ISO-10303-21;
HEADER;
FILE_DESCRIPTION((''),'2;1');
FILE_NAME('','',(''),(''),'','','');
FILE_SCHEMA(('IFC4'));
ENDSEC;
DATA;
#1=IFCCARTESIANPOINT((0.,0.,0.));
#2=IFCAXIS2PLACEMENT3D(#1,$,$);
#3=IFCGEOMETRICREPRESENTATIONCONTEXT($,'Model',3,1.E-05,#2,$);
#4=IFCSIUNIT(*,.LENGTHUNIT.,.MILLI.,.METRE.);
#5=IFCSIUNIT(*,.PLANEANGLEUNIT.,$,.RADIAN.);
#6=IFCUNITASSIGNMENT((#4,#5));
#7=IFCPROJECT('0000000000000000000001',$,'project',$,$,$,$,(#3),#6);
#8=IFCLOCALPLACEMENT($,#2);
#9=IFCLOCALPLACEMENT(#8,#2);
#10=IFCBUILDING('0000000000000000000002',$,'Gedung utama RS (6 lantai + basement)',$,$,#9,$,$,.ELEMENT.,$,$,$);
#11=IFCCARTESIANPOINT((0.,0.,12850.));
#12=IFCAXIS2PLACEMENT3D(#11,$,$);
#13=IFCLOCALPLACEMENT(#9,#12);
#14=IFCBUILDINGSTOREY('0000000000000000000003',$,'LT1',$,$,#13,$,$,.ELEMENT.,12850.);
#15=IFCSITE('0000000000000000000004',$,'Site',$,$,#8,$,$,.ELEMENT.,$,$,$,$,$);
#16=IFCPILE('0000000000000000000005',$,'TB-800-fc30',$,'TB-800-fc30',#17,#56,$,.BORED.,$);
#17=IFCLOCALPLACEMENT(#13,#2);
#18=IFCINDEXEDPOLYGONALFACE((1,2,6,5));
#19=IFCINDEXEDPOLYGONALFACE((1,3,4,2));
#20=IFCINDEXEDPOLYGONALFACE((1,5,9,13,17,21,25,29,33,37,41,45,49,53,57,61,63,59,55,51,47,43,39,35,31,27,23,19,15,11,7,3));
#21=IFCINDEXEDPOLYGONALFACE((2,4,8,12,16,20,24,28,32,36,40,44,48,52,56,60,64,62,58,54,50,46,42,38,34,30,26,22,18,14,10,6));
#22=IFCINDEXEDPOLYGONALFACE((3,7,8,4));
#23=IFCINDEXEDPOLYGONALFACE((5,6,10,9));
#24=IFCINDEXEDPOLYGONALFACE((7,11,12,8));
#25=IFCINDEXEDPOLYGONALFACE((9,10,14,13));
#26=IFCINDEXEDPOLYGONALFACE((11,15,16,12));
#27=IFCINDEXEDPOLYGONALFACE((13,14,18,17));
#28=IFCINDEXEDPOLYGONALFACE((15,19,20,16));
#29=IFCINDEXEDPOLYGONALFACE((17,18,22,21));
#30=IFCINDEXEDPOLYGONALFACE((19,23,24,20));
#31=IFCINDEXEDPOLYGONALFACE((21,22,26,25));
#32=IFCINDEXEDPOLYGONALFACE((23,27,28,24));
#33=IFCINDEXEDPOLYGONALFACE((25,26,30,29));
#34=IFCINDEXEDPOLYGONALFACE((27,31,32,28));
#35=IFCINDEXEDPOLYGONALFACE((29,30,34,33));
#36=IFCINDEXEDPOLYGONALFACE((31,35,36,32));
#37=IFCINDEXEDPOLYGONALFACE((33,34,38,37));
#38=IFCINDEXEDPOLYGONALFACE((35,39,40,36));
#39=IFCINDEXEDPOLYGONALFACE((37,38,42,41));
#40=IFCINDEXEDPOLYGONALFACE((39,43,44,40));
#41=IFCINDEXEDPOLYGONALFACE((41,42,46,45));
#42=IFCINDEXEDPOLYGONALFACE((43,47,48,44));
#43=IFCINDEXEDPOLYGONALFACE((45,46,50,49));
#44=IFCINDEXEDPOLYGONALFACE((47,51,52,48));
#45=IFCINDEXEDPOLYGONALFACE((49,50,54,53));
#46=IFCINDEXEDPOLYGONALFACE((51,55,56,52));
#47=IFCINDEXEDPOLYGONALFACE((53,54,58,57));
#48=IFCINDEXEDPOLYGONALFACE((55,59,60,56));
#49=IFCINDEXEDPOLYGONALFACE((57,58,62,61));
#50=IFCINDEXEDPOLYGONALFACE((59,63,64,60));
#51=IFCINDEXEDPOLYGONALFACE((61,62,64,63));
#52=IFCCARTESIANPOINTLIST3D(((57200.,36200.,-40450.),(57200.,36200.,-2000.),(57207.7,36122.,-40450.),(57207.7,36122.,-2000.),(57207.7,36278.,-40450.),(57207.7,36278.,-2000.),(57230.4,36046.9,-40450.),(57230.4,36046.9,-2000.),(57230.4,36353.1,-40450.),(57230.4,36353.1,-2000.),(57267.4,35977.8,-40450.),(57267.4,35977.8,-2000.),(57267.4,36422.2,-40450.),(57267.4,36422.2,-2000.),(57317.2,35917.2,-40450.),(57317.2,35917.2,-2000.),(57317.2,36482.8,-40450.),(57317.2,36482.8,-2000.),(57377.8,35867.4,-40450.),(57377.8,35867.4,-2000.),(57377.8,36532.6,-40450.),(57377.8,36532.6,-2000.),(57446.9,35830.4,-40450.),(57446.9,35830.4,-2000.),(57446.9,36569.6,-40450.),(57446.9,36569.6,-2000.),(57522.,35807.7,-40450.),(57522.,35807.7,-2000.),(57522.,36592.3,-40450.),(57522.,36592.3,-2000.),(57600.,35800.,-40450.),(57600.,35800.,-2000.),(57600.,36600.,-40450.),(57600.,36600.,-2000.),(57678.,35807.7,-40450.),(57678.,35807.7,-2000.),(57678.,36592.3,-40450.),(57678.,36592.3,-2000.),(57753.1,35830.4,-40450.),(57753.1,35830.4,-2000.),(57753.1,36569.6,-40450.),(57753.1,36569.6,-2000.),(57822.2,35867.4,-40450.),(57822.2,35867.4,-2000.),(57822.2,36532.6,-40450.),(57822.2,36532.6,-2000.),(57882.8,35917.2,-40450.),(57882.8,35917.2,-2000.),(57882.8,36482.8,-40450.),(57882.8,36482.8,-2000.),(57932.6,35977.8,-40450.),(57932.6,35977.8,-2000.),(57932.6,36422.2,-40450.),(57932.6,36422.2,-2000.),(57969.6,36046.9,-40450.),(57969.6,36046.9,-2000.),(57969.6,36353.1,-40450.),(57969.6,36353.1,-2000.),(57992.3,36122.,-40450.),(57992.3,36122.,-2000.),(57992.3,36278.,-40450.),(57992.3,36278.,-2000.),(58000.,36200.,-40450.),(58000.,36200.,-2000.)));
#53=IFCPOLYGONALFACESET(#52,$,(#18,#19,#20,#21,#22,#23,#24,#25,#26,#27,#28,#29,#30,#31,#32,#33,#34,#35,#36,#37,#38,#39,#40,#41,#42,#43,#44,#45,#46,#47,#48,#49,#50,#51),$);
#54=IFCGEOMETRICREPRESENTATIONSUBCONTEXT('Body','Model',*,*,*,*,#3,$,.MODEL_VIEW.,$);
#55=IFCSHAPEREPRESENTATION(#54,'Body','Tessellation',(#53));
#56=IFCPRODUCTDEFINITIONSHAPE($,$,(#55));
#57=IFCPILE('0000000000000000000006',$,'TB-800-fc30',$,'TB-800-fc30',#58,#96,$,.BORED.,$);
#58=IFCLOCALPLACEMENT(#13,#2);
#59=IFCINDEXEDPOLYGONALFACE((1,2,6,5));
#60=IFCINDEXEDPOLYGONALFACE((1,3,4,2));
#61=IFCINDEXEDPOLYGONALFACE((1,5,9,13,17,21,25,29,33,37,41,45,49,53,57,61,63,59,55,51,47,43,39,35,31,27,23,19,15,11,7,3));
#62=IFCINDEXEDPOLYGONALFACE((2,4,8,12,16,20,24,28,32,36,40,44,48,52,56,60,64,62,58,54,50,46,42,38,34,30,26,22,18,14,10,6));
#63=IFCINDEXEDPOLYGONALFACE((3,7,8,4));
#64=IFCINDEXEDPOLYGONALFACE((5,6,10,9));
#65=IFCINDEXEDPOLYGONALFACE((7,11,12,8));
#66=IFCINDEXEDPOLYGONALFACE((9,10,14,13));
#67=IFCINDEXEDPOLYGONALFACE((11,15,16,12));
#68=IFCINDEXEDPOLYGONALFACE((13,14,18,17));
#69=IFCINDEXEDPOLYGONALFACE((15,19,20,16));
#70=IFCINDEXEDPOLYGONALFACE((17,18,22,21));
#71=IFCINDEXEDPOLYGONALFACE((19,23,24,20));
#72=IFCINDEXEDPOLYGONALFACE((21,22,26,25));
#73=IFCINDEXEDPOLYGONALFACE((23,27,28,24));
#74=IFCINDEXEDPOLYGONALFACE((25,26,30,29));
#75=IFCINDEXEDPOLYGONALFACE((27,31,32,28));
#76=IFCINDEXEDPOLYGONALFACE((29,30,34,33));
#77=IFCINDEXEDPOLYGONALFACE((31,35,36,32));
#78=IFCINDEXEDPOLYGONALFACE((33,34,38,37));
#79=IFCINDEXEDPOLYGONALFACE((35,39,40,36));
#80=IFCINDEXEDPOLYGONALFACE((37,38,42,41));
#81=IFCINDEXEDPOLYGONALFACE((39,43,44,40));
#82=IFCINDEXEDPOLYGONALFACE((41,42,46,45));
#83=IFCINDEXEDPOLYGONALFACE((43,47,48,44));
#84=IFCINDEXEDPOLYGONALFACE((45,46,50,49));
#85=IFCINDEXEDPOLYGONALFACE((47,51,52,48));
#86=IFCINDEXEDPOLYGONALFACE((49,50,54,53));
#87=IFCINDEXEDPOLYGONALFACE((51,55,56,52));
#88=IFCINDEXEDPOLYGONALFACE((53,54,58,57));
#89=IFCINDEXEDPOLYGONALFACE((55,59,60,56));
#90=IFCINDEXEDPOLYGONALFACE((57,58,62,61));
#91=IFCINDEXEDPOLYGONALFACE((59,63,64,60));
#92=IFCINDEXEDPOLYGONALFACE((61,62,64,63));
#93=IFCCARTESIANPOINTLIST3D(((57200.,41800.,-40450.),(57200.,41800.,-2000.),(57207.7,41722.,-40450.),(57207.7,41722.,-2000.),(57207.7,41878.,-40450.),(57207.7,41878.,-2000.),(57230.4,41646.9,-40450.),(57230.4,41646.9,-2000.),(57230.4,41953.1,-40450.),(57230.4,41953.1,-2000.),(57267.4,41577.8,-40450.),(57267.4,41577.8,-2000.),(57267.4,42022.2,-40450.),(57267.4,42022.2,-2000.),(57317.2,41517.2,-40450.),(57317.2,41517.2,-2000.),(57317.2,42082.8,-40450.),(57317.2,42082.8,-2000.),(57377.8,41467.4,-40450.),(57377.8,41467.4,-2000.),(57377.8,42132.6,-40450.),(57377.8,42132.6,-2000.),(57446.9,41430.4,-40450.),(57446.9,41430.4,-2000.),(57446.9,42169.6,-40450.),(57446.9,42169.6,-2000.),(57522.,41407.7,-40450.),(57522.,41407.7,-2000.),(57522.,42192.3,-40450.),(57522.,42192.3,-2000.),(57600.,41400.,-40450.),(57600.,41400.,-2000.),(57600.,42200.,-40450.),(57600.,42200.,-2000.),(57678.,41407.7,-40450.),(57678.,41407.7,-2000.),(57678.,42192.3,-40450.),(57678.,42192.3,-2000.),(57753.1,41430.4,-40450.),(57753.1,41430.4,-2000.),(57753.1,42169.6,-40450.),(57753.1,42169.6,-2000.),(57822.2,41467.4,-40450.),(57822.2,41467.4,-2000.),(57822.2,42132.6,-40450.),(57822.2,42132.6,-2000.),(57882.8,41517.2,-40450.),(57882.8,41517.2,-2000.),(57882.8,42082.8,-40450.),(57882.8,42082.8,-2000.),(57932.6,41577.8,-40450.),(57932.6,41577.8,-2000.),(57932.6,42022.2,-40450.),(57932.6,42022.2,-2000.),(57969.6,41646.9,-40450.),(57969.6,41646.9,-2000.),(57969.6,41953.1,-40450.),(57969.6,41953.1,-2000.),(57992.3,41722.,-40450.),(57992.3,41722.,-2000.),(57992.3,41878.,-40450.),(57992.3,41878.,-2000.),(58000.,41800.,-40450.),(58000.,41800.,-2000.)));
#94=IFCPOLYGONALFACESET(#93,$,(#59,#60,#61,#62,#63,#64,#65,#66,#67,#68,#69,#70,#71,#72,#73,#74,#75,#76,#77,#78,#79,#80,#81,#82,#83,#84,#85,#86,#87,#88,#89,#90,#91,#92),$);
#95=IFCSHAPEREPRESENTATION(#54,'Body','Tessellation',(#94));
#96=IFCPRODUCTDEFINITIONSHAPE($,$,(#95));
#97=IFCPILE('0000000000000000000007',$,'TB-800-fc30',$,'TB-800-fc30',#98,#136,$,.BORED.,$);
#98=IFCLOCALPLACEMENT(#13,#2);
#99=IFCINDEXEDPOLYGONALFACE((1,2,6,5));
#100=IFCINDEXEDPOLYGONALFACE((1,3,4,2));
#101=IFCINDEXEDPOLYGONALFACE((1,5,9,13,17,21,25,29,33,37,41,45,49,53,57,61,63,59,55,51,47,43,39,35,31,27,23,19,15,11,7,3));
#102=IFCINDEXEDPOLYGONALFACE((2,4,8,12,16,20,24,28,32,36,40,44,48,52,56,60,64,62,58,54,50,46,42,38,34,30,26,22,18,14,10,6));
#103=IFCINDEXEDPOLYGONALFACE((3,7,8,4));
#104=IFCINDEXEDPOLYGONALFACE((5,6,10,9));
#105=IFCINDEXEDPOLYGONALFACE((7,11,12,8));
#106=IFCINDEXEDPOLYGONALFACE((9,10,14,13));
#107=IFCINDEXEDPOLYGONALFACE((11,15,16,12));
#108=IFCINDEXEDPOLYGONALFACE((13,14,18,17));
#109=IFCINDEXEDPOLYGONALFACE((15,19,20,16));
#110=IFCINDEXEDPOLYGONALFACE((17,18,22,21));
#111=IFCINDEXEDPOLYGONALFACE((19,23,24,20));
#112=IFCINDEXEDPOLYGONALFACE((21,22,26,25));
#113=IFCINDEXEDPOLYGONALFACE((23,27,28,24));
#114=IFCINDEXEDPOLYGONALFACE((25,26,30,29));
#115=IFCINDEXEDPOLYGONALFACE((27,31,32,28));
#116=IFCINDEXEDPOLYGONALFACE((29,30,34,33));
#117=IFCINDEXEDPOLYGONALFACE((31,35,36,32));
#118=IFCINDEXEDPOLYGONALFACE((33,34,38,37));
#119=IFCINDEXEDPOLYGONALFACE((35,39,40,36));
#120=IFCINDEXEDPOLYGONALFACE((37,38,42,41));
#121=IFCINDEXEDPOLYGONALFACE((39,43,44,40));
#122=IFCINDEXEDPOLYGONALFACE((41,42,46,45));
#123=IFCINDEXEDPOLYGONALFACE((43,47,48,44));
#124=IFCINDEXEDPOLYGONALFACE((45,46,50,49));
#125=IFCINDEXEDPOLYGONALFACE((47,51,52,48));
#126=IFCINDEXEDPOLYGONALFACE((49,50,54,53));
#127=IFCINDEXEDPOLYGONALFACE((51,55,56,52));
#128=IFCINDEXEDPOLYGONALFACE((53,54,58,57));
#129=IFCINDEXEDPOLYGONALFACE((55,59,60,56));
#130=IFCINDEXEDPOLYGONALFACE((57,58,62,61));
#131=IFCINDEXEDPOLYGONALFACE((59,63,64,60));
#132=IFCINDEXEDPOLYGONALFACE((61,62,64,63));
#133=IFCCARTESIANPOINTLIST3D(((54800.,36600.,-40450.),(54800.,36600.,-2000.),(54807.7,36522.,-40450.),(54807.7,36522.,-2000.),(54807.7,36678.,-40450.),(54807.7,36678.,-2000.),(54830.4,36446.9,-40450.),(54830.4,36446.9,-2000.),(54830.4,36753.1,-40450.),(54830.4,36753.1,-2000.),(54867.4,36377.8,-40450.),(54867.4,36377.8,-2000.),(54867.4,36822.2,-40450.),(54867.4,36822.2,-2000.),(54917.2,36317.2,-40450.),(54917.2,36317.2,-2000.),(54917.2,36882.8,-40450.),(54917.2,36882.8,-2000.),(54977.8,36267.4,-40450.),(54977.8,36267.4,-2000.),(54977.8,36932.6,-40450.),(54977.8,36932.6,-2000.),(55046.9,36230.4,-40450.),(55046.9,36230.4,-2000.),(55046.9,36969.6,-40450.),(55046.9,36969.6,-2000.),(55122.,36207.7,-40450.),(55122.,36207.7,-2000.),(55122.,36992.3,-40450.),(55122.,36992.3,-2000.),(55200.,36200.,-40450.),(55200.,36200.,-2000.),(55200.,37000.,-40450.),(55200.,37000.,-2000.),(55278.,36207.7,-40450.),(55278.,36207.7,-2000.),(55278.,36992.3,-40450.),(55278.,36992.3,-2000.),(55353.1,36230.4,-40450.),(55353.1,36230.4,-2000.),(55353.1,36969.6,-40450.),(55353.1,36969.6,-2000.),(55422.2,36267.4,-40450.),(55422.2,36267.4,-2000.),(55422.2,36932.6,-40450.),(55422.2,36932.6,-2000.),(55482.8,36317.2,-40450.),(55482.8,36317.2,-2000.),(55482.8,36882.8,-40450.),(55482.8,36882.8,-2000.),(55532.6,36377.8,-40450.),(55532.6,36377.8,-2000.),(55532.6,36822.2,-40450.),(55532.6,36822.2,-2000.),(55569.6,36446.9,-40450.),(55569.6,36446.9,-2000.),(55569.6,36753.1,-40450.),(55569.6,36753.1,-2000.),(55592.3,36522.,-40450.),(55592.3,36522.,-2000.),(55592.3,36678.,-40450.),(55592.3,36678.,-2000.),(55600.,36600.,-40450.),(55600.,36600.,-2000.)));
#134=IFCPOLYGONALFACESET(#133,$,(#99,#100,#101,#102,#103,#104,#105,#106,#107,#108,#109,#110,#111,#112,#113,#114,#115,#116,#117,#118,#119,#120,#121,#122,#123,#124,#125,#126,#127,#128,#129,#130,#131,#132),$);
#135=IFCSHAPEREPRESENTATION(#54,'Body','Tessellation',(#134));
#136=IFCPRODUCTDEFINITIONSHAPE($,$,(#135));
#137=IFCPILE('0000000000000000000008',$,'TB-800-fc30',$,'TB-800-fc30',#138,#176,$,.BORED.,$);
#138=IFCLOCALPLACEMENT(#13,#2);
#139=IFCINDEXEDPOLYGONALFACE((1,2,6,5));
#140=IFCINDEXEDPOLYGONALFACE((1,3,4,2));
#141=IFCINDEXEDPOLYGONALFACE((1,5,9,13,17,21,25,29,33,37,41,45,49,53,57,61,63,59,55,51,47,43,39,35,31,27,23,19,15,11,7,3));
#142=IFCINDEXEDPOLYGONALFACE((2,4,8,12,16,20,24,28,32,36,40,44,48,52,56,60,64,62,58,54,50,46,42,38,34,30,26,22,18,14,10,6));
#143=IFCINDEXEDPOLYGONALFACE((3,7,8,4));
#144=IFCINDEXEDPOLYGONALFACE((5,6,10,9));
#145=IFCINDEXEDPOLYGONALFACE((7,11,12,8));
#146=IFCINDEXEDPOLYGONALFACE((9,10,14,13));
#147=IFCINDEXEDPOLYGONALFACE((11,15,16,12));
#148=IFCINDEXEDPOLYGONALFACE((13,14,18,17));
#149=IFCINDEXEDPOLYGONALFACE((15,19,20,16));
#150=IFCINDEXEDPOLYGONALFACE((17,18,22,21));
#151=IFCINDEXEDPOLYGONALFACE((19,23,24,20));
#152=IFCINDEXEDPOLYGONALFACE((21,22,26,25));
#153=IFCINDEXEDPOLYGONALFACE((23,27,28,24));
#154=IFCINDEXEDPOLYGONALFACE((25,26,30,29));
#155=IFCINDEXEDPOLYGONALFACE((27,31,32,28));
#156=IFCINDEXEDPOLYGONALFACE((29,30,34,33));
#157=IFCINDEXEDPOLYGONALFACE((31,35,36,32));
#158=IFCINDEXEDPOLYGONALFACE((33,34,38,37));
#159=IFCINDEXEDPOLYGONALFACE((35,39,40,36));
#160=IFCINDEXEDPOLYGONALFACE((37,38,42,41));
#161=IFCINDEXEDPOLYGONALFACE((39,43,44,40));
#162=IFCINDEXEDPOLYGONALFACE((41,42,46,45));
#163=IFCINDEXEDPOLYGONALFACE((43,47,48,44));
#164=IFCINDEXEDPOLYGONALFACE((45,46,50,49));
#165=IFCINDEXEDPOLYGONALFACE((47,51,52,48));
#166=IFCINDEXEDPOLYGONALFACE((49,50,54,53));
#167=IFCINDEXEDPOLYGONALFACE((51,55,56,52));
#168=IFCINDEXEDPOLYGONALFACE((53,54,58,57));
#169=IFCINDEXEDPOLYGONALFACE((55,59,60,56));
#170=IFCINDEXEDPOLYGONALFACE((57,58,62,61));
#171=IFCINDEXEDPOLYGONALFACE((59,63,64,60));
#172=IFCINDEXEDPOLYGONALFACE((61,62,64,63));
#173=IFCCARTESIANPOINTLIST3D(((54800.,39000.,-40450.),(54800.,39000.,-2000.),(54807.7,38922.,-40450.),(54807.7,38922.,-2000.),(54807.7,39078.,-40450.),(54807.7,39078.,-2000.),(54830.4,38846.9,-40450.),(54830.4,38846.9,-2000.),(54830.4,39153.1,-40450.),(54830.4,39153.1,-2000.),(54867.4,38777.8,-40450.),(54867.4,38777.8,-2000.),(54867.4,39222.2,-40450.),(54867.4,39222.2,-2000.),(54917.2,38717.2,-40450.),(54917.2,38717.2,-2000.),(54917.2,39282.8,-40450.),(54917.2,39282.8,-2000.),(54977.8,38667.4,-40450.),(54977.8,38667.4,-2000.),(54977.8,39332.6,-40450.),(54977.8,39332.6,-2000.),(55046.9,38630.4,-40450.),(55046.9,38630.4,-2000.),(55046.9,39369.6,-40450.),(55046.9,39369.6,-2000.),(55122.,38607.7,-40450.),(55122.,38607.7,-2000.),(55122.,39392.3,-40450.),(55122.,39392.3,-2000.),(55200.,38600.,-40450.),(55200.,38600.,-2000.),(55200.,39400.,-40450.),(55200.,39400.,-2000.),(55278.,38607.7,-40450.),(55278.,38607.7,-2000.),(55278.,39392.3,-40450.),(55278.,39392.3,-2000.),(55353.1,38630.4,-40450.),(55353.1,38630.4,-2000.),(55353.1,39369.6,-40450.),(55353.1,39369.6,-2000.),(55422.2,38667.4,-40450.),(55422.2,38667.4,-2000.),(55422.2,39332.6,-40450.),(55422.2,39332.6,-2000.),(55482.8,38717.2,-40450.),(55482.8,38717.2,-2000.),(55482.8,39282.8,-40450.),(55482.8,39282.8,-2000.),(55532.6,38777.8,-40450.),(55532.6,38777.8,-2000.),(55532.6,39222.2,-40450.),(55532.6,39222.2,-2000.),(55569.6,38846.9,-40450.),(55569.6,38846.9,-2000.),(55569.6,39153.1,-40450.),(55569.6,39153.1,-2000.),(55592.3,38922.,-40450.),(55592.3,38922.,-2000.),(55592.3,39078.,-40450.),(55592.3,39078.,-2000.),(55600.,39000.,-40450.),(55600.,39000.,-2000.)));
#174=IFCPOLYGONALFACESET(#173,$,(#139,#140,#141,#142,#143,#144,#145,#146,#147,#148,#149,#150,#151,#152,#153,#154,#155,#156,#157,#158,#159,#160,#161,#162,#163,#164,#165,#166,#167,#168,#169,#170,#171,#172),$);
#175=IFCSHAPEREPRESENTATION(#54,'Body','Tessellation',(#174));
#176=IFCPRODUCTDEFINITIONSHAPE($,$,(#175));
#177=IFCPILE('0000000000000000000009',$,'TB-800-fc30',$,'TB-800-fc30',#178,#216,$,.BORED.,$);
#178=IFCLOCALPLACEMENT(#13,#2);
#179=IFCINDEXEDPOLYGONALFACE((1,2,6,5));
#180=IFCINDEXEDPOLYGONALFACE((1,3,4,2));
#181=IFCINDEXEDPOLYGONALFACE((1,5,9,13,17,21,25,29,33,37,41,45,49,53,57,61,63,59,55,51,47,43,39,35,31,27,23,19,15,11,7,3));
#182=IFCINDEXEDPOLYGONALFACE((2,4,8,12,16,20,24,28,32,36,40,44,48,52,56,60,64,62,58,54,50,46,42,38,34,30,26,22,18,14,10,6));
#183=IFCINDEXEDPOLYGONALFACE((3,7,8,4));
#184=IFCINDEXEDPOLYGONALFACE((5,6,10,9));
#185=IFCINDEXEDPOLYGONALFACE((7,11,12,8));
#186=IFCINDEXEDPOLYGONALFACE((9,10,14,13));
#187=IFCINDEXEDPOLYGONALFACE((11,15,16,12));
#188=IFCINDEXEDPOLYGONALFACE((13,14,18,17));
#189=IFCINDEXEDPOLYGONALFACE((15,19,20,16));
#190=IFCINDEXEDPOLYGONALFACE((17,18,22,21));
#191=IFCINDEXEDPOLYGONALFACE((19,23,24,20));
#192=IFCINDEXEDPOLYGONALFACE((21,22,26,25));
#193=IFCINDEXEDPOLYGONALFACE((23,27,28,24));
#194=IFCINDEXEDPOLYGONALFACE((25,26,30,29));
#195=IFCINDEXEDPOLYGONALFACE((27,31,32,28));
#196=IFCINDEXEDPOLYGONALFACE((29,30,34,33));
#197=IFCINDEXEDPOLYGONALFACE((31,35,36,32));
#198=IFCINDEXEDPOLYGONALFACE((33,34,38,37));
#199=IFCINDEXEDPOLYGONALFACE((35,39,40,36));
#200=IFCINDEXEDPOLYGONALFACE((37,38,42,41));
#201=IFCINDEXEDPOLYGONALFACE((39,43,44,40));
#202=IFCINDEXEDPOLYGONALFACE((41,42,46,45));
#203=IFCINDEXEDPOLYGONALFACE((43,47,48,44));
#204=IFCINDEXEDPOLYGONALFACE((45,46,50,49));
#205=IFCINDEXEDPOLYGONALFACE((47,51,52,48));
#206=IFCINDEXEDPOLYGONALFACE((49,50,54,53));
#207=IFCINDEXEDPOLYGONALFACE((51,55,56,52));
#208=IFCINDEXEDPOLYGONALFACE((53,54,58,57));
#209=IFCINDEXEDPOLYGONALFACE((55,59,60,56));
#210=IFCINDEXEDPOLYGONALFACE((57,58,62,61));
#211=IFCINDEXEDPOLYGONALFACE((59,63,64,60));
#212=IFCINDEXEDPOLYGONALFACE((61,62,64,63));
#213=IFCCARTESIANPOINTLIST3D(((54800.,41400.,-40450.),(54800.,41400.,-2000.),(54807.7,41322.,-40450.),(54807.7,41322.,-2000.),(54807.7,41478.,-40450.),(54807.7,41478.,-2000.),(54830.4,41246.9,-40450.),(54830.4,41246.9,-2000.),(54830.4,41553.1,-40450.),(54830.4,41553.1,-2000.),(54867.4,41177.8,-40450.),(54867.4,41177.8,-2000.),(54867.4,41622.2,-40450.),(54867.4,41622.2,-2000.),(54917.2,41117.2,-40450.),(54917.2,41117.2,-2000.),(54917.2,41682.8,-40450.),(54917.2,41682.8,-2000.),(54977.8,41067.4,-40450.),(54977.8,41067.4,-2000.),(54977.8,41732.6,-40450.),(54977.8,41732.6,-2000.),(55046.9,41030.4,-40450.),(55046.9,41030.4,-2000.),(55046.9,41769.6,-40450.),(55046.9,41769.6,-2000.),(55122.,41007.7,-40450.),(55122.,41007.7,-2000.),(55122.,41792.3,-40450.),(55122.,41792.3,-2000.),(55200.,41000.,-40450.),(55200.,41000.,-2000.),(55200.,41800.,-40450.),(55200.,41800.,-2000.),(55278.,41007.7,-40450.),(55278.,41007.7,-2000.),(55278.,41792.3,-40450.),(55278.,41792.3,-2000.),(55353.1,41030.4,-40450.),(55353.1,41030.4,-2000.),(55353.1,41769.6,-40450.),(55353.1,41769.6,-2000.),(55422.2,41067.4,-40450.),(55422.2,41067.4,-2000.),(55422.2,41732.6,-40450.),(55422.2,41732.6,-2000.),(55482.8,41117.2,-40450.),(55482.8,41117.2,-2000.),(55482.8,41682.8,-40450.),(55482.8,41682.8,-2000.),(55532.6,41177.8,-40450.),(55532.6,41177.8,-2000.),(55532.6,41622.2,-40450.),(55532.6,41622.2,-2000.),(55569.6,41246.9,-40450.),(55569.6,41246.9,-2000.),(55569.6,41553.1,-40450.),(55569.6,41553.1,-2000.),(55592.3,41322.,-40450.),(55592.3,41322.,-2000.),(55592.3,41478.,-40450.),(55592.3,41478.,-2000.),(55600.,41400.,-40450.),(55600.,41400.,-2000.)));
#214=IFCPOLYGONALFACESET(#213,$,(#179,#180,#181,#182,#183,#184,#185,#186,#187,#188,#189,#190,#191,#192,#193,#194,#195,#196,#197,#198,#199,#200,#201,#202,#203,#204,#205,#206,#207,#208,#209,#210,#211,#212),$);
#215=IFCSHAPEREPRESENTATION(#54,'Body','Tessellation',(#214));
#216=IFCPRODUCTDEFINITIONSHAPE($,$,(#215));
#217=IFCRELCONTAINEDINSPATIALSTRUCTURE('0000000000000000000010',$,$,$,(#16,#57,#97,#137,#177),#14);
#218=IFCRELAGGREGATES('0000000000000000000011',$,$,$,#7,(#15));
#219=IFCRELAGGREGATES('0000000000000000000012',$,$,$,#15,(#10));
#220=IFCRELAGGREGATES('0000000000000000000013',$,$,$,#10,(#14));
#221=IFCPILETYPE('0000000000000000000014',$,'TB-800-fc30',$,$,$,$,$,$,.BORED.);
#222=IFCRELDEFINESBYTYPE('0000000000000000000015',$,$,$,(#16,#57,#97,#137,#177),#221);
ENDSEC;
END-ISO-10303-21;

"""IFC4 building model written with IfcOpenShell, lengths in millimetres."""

from ifc_helpers import new_model, si_unit, frame, origin, origin_2d, place, context, subcontext, project, spatial, circle, extrude, material_profile, profile_set, profile_usage, type_object, element, save


model = new_model("IFC4")

# Units and contexts
model_context = context("Model", 3, precision=1e-05, world=origin())
body_context = subcontext(model_context, "Body", "Model", "MODEL_VIEW")
ifc_project = project(units=[si_unit("LENGTHUNIT", "METRE", prefix="MILLI"), si_unit("PLANEANGLEUNIT", "RADIAN")], contexts=[model_context])

# Site, building, storey
site_placement = place(None, origin())
site = spatial("IfcSite", under=ifc_project, at=site_placement, Name="Site", CompositionType="ELEMENT")
building_placement = place(site_placement, origin())
building = spatial("IfcBuilding", under=site, at=building_placement, Name="Gedung utama RS (6 lantai + basement)", CompositionType="ELEMENT")
storey_placement = place(building_placement, frame((0.0, 0.0, 12850.0)))
storey = spatial("IfcBuildingStorey", under=building, at=storey_placement, Name="LT1", CompositionType="ELEMENT", Elevation=12850.0)

# Piles
ifc_material_profile_1 = material_profile(None, circle(Radius=400.0, at=origin_2d()), Name="TB-800-fc30")
ifc_profile_set_1 = profile_set([ifc_material_profile_1], Name="TB-800-fc30")
ifc_profile_usage_1 = profile_usage(ifc_profile_set_1, cardinal=5)
pile_type = type_object("IfcPileType", Name="TB-800-fc30", PredefinedType="BORED", material=ifc_profile_set_1)
for number, where, z_axis, x_axis, name in (
    (1, (57600.0, 36200.0, -40450.0), (0.0, 0.0, 1.0), (1.0, 0.0, 0.0), "TB-800-fc30"),
    (2, (57600.0, 41800.0, -40450.0), (0.0, 0.0, 1.0), (1.0, 0.0, 0.0), "TB-800-fc30"),
    (3, (55200.0, 36600.0, -40450.0), (0.0, 0.0, 1.0), (1.0, 0.0, 0.0), "TB-800-fc30"),
    (4, (55200.0, 39000.0, -40450.0), (0.0, 0.0, 1.0), (1.0, 0.0, 0.0), "TB-800-fc30"),
    (5, (55200.0, 41400.0, -40450.0), (0.0, 0.0, 1.0), (1.0, 0.0, 0.0), "TB-800-fc30"),
):
    element("IfcPile", number, at=place(storey_placement, frame(where, z_axis=z_axis, x_axis=x_axis)), inside=storey, type_object=pile_type, material=ifc_profile_usage_1, Name=name, ObjectType="TB-800-fc30", PredefinedType="BORED", context=body_context, shape_type="SweptSolid", body=[
        extrude(circle(Radius=400.0, at=origin_2d()), origin(), (0.0, 0.0, 1.0), 38450.0),
    ])

save(model, "model.ifc")
